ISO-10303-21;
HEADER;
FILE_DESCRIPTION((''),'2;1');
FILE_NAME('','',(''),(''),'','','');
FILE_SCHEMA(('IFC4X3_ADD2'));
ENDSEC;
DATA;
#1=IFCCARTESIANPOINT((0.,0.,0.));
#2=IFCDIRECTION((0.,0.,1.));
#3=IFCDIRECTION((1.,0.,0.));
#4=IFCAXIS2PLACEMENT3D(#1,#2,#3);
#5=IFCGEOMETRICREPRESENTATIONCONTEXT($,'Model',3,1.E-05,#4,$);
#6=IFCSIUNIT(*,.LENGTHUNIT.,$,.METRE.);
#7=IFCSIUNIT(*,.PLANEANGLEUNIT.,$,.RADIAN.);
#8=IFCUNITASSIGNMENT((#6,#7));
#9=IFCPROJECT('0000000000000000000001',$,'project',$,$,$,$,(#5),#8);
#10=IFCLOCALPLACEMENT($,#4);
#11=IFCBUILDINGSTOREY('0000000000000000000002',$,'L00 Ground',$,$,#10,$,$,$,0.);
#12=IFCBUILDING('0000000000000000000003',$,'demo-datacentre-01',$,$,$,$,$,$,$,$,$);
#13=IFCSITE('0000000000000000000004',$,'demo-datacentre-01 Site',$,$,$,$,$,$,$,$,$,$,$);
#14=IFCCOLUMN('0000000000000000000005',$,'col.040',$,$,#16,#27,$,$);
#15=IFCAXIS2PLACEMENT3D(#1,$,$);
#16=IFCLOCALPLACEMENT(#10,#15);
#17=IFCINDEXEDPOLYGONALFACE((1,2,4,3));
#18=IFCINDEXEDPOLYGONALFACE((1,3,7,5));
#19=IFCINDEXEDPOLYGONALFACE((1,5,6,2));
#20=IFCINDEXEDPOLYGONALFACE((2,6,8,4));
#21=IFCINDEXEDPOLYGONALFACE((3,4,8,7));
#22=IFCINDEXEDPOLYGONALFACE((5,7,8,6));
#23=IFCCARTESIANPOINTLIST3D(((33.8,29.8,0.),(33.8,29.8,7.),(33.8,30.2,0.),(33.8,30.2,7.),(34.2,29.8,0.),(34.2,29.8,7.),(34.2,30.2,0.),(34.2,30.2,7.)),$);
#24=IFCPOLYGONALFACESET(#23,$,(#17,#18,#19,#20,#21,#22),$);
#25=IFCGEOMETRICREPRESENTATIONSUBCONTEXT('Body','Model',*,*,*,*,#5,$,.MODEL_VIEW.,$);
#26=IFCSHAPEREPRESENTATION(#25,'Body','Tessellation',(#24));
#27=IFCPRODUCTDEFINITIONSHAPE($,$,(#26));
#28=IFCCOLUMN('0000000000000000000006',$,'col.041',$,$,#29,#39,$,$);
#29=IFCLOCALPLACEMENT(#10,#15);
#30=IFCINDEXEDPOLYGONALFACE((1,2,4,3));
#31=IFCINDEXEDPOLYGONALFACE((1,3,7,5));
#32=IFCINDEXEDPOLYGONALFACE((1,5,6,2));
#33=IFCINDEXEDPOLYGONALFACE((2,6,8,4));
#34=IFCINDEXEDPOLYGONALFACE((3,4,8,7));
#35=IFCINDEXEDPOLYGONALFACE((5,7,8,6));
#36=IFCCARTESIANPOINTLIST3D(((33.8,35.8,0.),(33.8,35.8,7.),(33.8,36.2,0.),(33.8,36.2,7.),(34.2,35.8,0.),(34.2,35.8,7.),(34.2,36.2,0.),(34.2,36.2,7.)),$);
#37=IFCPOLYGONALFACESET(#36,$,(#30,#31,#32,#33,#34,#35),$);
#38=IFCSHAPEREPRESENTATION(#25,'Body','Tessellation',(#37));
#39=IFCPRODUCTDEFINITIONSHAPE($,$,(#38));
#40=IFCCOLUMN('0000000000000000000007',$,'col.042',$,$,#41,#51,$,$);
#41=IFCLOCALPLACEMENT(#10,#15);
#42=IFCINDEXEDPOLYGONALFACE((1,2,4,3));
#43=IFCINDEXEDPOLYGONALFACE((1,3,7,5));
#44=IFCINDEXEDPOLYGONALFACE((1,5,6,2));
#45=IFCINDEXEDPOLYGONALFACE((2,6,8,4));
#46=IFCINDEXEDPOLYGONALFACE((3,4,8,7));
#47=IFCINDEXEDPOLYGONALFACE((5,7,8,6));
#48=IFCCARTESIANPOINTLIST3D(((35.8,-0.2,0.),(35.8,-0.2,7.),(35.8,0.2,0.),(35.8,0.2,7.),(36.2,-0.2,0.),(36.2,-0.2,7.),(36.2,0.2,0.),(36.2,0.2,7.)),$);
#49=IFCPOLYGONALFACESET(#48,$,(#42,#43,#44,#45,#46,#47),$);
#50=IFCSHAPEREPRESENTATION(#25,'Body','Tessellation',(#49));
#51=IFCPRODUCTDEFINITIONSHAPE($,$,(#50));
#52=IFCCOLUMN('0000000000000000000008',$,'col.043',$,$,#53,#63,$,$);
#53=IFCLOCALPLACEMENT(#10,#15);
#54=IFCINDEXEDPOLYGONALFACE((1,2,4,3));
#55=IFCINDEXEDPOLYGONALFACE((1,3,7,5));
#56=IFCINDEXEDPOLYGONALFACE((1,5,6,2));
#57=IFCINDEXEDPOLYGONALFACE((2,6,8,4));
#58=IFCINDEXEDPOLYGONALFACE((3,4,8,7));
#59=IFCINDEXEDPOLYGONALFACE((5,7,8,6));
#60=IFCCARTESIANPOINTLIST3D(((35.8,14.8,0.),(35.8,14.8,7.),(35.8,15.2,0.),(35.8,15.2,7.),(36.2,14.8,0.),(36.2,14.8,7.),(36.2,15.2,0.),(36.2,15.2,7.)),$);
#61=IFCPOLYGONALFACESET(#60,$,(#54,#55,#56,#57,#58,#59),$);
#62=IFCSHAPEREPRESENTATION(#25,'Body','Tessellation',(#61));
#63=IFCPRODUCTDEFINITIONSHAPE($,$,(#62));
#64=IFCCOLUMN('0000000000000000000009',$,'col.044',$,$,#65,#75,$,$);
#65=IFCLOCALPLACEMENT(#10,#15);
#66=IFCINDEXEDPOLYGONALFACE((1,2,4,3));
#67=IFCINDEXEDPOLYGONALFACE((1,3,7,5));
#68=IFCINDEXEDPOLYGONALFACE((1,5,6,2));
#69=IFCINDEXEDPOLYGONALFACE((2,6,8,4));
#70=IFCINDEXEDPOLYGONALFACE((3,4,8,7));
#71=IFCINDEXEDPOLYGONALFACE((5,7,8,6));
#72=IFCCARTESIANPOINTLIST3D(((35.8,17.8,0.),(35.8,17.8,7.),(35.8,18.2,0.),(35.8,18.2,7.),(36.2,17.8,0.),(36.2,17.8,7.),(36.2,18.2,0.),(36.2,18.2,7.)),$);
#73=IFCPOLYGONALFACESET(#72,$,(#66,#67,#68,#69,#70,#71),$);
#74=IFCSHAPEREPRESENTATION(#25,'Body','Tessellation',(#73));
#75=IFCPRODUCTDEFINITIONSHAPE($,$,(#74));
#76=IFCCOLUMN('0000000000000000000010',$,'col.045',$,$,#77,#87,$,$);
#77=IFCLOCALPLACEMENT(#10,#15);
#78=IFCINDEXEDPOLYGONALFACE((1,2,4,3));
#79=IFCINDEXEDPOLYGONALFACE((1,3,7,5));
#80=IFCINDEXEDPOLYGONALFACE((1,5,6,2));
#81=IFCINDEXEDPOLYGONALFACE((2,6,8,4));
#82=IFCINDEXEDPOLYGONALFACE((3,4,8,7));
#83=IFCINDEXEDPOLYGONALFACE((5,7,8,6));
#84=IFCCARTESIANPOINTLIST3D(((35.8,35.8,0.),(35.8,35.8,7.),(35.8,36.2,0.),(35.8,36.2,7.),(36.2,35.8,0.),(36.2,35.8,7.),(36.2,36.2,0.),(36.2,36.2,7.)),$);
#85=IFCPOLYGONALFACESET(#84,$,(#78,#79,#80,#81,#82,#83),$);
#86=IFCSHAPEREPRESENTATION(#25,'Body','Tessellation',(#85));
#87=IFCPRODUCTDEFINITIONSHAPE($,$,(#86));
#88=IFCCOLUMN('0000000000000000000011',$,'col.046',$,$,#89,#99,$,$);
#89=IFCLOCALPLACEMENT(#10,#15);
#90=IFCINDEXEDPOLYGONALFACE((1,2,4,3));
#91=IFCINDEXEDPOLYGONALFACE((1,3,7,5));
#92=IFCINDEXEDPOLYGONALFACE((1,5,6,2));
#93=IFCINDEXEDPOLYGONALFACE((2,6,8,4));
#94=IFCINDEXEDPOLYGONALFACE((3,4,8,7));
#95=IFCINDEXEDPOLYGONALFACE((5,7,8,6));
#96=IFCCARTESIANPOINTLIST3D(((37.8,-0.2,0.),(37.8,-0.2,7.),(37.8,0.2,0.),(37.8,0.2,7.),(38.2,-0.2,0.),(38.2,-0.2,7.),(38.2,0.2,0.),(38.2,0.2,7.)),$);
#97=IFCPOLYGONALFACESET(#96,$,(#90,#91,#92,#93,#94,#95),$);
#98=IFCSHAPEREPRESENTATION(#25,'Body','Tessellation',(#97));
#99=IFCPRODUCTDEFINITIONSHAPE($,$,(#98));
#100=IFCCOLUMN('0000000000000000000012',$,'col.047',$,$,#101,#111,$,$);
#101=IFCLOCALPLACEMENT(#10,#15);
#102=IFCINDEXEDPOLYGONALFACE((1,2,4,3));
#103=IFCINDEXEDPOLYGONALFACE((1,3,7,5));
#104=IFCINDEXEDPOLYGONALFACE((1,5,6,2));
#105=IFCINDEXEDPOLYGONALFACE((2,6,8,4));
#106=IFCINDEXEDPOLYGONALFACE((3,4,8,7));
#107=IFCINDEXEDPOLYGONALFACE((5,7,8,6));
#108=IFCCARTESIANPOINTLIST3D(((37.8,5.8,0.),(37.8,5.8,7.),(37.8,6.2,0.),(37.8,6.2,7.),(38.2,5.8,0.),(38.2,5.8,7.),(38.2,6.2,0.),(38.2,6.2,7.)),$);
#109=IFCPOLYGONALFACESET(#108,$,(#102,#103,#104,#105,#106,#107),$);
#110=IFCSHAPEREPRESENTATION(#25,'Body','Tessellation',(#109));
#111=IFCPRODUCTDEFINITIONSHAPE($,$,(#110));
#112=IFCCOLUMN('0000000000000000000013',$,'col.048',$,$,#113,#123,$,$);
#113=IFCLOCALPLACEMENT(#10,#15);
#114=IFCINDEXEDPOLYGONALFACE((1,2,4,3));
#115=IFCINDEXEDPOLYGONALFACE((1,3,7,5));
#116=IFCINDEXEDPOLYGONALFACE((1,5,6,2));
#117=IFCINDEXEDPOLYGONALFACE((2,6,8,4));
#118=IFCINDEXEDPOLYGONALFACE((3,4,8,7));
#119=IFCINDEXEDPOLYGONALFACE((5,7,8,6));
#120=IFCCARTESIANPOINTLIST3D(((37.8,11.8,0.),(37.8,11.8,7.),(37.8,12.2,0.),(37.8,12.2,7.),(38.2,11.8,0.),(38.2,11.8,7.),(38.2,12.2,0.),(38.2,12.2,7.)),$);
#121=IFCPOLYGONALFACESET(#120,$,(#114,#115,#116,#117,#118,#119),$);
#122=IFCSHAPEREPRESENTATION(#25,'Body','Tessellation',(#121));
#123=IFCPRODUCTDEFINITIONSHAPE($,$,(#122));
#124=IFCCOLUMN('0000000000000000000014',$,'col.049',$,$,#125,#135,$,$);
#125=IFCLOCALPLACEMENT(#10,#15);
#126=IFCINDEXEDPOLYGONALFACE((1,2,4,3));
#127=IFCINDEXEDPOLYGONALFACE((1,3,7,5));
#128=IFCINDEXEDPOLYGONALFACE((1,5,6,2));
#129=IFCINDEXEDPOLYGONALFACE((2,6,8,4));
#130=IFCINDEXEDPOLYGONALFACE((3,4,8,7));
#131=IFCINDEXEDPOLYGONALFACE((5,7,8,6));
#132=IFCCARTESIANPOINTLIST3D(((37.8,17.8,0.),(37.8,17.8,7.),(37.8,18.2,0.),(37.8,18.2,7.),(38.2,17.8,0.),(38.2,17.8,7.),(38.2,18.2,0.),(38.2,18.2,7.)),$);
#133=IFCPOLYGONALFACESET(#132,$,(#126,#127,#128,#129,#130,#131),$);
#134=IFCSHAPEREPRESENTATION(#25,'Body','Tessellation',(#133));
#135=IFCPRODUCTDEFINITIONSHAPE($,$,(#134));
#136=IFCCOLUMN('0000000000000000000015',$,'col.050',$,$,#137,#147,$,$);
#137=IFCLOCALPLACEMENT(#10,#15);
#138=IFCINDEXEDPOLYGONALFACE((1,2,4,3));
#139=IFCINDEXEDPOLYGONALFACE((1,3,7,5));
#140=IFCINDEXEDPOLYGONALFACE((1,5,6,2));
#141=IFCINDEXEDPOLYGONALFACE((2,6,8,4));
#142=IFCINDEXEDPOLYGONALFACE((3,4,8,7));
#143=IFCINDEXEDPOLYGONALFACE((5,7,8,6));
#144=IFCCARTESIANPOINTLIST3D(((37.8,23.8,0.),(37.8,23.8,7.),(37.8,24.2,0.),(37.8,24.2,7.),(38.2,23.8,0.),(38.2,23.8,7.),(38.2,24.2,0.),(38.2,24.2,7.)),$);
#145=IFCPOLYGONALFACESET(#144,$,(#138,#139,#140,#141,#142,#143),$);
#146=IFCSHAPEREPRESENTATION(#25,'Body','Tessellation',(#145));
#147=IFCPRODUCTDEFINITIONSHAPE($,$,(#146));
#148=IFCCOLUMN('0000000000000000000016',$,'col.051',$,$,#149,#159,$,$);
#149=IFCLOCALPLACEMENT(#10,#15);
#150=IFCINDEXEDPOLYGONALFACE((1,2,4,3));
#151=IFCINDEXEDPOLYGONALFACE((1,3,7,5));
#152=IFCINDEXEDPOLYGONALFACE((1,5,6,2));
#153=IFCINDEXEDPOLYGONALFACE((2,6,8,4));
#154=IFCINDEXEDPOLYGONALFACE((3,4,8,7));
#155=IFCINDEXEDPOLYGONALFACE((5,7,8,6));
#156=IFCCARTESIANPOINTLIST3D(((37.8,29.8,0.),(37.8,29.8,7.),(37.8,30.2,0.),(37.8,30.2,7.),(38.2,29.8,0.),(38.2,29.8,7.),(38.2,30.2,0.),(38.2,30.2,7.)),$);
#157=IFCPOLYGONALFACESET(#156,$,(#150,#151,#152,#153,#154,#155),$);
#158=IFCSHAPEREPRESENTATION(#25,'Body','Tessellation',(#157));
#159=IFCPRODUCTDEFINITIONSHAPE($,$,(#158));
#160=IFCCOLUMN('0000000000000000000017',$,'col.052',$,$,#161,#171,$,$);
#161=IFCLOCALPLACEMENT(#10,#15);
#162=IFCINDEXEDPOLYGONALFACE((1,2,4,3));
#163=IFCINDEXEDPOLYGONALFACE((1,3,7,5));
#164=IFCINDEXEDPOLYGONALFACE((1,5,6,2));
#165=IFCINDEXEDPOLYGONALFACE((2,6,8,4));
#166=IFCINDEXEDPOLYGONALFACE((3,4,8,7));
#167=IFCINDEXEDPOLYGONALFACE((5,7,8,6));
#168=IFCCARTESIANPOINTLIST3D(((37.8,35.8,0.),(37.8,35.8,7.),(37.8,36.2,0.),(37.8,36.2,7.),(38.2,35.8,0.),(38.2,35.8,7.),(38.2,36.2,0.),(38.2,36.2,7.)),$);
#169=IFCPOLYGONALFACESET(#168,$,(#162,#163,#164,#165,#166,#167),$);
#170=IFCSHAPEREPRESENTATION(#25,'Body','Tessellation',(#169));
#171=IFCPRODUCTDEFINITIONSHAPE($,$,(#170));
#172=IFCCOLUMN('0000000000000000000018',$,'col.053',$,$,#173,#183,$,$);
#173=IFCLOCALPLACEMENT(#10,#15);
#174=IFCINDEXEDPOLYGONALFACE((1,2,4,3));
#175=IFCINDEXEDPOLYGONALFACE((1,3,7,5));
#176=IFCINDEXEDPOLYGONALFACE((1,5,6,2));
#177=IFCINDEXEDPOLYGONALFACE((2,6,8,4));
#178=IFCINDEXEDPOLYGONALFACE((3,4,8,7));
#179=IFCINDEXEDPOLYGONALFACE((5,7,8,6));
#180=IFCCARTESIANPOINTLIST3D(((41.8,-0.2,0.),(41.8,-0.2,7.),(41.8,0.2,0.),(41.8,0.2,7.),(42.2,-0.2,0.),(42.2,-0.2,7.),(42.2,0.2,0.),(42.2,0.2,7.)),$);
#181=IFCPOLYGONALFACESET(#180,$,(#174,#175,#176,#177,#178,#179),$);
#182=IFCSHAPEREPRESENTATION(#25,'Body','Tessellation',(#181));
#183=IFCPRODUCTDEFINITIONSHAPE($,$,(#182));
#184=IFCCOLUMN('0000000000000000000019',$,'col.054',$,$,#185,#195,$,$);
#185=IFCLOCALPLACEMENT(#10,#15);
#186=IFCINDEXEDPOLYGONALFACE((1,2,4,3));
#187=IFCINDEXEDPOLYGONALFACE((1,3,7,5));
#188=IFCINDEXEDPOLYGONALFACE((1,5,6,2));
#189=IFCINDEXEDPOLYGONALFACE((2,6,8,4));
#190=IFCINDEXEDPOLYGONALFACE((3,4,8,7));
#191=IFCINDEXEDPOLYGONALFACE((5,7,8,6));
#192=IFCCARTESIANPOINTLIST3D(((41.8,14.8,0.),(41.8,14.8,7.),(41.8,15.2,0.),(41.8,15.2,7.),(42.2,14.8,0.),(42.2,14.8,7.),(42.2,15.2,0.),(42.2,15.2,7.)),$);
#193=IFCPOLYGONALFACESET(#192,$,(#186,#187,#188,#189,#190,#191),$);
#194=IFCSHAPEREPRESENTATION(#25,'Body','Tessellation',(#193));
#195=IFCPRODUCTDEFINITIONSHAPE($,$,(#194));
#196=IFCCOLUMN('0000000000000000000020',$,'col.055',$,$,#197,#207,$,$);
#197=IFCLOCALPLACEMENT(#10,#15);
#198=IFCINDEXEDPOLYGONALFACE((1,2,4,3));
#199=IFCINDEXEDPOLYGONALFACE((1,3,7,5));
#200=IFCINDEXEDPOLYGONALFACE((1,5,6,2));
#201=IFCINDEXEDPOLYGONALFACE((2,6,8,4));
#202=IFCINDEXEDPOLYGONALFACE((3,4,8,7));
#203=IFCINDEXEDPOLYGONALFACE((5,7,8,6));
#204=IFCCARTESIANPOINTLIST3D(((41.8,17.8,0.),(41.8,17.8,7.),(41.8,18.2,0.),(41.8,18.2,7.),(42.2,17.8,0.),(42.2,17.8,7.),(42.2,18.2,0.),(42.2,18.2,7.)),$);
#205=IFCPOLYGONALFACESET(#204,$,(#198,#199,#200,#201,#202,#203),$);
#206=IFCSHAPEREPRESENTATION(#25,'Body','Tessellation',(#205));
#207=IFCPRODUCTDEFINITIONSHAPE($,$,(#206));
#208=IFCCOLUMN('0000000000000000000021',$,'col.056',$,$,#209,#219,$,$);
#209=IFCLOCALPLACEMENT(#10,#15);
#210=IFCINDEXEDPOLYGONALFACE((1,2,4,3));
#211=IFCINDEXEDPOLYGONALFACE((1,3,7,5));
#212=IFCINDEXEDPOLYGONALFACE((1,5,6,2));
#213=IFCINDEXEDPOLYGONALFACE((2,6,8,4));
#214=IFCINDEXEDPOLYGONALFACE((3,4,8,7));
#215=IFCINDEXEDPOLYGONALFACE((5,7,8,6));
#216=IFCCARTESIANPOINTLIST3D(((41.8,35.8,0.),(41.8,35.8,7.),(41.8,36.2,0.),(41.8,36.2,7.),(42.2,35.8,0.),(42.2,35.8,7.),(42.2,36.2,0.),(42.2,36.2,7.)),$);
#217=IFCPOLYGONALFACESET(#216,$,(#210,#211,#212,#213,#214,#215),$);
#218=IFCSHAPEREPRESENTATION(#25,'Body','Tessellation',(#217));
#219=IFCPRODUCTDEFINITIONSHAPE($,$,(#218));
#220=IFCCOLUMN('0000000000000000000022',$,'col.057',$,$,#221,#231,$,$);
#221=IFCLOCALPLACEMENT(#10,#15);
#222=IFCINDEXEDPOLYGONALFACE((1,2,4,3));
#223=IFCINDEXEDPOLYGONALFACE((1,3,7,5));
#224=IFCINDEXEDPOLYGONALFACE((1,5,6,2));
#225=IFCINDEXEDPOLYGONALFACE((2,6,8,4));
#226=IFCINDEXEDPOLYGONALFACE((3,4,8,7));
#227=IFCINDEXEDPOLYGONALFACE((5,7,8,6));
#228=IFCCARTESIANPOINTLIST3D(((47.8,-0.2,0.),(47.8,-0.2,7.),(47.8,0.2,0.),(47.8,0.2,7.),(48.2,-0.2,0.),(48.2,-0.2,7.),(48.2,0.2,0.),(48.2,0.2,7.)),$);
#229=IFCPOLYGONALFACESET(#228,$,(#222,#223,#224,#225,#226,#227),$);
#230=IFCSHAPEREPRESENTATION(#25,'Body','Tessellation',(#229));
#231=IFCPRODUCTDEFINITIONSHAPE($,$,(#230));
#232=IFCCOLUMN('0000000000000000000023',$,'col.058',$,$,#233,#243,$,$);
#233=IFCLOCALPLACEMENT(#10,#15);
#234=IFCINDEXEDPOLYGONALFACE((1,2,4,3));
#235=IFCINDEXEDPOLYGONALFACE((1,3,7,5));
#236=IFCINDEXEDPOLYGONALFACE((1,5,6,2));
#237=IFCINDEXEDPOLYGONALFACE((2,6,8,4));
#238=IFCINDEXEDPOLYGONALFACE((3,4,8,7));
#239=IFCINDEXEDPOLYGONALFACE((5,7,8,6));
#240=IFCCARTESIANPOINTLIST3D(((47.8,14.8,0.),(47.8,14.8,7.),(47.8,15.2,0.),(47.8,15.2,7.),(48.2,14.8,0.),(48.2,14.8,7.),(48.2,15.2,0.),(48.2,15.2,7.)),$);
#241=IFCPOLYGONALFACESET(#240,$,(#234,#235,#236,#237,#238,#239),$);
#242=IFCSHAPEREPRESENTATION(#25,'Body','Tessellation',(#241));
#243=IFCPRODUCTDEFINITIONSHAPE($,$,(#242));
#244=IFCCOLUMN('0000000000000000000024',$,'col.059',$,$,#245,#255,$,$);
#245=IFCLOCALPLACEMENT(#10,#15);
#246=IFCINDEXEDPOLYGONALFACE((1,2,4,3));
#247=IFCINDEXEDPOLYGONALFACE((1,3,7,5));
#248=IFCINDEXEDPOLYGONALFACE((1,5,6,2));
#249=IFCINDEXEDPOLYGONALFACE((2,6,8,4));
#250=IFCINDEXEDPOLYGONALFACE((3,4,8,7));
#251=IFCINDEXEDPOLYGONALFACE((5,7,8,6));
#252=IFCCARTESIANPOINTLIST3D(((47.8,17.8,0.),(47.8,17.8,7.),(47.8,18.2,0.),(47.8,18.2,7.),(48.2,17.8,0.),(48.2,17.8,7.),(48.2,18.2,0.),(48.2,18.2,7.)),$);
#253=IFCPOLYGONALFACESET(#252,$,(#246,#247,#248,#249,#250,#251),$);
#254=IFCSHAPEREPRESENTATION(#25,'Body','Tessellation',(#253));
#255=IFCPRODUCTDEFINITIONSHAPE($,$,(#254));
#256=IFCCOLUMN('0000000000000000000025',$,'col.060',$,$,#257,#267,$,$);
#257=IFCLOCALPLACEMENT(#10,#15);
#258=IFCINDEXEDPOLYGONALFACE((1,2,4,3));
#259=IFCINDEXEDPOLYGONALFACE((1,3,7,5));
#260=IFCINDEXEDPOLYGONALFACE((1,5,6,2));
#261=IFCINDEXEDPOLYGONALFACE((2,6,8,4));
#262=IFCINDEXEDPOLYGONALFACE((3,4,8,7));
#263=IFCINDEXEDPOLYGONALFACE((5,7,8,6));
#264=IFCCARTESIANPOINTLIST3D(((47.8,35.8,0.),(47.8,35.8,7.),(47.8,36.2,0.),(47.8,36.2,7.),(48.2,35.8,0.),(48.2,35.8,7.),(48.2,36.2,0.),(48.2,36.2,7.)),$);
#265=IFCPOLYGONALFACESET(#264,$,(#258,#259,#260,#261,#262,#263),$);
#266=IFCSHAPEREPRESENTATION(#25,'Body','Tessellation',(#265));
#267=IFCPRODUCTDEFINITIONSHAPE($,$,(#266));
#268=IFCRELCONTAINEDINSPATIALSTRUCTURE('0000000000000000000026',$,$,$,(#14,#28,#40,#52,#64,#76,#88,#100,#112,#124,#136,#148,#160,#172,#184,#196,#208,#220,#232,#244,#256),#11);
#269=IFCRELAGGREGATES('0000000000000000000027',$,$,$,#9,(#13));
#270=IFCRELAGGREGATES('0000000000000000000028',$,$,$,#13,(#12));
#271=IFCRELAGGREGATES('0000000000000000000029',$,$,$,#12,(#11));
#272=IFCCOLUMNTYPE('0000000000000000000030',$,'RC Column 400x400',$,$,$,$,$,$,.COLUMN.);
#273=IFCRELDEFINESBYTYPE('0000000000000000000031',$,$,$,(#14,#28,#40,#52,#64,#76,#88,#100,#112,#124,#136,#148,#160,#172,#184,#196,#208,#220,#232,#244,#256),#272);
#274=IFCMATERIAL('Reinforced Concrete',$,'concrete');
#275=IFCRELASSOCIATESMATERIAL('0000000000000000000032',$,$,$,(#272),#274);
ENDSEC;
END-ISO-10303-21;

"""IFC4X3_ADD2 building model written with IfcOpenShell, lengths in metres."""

from ifc_helpers import new_model, si_unit, frame, origin_with_axes, place, context, subcontext, project, spatial, rectangle, extrude, material, type_object, element, save


model = new_model("IFC4X3_ADD2")

# Units and contexts
model_context = context("Model", 3, precision=1e-05, world=origin_with_axes())
body_context = subcontext(model_context, "Body", "Model", "MODEL_VIEW")
ifc_project = project(units=[si_unit("LENGTHUNIT", "METRE"), si_unit("PLANEANGLEUNIT", "RADIAN")], contexts=[model_context])

# Site, building, storey
site = spatial("IfcSite", under=ifc_project, Name="demo-datacentre-01 Site")
building = spatial("IfcBuilding", under=site, Name="demo-datacentre-01")
storey_placement = place(None, origin_with_axes())
storey = spatial("IfcBuildingStorey", under=building, at=storey_placement, Name="L00 Ground", Elevation=0.0)

# Columns
ifc_material = material(Name="Reinforced Concrete", Category="concrete")
column_type = type_object("IfcColumnType", Name="RC Column 400x400", PredefinedType="COLUMN", material=ifc_material)
for number, where, z_axis, x_axis, name in (
    (1, (34.0, 30.0, 0.0), (0.0, 0.0, 1.0), (1.0, 0.0, 0.0), "col.040"),
    (2, (34.0, 36.0, 0.0), (0.0, 0.0, 1.0), (1.0, 0.0, 0.0), "col.041"),
    (3, (36.0, 0.0, 0.0), (0.0, 0.0, 1.0), (1.0, 0.0, 0.0), "col.042"),
    (4, (36.0, 15.0, 0.0), (0.0, 0.0, 1.0), (1.0, 0.0, 0.0), "col.043"),
    (5, (36.0, 18.0, 0.0), (0.0, 0.0, 1.0), (1.0, 0.0, 0.0), "col.044"),
    (6, (36.0, 36.0, 0.0), (0.0, 0.0, 1.0), (1.0, 0.0, 0.0), "col.045"),
    (7, (38.0, 0.0, 0.0), (0.0, 0.0, 1.0), (1.0, 0.0, 0.0), "col.046"),
    (8, (38.0, 6.0, 0.0), (0.0, 0.0, 1.0), (1.0, 0.0, 0.0), "col.047"),
    (9, (38.0, 12.0, 0.0), (0.0, 0.0, 1.0), (1.0, 0.0, 0.0), "col.048"),
    (10, (38.0, 18.0, 0.0), (0.0, 0.0, 1.0), (1.0, 0.0, 0.0), "col.049"),
    (11, (38.0, 24.0, 0.0), (0.0, 0.0, 1.0), (1.0, 0.0, 0.0), "col.050"),
    (12, (38.0, 30.0, 0.0), (0.0, 0.0, 1.0), (1.0, 0.0, 0.0), "col.051"),
    (13, (38.0, 36.0, 0.0), (0.0, 0.0, 1.0), (1.0, 0.0, 0.0), "col.052"),
    (14, (42.0, 0.0, 0.0), (0.0, 0.0, 1.0), (1.0, 0.0, 0.0), "col.053"),
    (15, (42.0, 15.0, 0.0), (0.0, 0.0, 1.0), (1.0, 0.0, 0.0), "col.054"),
    (16, (42.0, 18.0, 0.0), (0.0, 0.0, 1.0), (1.0, 0.0, 0.0), "col.055"),
    (17, (42.0, 36.0, 0.0), (0.0, 0.0, 1.0), (1.0, 0.0, 0.0), "col.056"),
    (18, (48.0, 0.0, 0.0), (0.0, 0.0, 1.0), (1.0, 0.0, 0.0), "col.057"),
    (19, (48.0, 15.0, 0.0), (0.0, 0.0, 1.0), (1.0, 0.0, 0.0), "col.058"),
    (20, (48.0, 18.0, 0.0), (0.0, 0.0, 1.0), (1.0, 0.0, 0.0), "col.059"),
    (21, (48.0, 36.0, 0.0), (0.0, 0.0, 1.0), (1.0, 0.0, 0.0), "col.060"),
):
    element("IfcColumn", number, at=place(storey_placement, frame(where, z_axis=z_axis, x_axis=x_axis)), inside=storey, type_object=column_type, Name=name, context=body_context, shape_type="SweptSolid", body=[
        extrude(rectangle(XDim=0.4, YDim=0.4), origin_with_axes(), (0.0, 0.0, 1.0), 7.0),
    ])

save(model, "model.ifc")
